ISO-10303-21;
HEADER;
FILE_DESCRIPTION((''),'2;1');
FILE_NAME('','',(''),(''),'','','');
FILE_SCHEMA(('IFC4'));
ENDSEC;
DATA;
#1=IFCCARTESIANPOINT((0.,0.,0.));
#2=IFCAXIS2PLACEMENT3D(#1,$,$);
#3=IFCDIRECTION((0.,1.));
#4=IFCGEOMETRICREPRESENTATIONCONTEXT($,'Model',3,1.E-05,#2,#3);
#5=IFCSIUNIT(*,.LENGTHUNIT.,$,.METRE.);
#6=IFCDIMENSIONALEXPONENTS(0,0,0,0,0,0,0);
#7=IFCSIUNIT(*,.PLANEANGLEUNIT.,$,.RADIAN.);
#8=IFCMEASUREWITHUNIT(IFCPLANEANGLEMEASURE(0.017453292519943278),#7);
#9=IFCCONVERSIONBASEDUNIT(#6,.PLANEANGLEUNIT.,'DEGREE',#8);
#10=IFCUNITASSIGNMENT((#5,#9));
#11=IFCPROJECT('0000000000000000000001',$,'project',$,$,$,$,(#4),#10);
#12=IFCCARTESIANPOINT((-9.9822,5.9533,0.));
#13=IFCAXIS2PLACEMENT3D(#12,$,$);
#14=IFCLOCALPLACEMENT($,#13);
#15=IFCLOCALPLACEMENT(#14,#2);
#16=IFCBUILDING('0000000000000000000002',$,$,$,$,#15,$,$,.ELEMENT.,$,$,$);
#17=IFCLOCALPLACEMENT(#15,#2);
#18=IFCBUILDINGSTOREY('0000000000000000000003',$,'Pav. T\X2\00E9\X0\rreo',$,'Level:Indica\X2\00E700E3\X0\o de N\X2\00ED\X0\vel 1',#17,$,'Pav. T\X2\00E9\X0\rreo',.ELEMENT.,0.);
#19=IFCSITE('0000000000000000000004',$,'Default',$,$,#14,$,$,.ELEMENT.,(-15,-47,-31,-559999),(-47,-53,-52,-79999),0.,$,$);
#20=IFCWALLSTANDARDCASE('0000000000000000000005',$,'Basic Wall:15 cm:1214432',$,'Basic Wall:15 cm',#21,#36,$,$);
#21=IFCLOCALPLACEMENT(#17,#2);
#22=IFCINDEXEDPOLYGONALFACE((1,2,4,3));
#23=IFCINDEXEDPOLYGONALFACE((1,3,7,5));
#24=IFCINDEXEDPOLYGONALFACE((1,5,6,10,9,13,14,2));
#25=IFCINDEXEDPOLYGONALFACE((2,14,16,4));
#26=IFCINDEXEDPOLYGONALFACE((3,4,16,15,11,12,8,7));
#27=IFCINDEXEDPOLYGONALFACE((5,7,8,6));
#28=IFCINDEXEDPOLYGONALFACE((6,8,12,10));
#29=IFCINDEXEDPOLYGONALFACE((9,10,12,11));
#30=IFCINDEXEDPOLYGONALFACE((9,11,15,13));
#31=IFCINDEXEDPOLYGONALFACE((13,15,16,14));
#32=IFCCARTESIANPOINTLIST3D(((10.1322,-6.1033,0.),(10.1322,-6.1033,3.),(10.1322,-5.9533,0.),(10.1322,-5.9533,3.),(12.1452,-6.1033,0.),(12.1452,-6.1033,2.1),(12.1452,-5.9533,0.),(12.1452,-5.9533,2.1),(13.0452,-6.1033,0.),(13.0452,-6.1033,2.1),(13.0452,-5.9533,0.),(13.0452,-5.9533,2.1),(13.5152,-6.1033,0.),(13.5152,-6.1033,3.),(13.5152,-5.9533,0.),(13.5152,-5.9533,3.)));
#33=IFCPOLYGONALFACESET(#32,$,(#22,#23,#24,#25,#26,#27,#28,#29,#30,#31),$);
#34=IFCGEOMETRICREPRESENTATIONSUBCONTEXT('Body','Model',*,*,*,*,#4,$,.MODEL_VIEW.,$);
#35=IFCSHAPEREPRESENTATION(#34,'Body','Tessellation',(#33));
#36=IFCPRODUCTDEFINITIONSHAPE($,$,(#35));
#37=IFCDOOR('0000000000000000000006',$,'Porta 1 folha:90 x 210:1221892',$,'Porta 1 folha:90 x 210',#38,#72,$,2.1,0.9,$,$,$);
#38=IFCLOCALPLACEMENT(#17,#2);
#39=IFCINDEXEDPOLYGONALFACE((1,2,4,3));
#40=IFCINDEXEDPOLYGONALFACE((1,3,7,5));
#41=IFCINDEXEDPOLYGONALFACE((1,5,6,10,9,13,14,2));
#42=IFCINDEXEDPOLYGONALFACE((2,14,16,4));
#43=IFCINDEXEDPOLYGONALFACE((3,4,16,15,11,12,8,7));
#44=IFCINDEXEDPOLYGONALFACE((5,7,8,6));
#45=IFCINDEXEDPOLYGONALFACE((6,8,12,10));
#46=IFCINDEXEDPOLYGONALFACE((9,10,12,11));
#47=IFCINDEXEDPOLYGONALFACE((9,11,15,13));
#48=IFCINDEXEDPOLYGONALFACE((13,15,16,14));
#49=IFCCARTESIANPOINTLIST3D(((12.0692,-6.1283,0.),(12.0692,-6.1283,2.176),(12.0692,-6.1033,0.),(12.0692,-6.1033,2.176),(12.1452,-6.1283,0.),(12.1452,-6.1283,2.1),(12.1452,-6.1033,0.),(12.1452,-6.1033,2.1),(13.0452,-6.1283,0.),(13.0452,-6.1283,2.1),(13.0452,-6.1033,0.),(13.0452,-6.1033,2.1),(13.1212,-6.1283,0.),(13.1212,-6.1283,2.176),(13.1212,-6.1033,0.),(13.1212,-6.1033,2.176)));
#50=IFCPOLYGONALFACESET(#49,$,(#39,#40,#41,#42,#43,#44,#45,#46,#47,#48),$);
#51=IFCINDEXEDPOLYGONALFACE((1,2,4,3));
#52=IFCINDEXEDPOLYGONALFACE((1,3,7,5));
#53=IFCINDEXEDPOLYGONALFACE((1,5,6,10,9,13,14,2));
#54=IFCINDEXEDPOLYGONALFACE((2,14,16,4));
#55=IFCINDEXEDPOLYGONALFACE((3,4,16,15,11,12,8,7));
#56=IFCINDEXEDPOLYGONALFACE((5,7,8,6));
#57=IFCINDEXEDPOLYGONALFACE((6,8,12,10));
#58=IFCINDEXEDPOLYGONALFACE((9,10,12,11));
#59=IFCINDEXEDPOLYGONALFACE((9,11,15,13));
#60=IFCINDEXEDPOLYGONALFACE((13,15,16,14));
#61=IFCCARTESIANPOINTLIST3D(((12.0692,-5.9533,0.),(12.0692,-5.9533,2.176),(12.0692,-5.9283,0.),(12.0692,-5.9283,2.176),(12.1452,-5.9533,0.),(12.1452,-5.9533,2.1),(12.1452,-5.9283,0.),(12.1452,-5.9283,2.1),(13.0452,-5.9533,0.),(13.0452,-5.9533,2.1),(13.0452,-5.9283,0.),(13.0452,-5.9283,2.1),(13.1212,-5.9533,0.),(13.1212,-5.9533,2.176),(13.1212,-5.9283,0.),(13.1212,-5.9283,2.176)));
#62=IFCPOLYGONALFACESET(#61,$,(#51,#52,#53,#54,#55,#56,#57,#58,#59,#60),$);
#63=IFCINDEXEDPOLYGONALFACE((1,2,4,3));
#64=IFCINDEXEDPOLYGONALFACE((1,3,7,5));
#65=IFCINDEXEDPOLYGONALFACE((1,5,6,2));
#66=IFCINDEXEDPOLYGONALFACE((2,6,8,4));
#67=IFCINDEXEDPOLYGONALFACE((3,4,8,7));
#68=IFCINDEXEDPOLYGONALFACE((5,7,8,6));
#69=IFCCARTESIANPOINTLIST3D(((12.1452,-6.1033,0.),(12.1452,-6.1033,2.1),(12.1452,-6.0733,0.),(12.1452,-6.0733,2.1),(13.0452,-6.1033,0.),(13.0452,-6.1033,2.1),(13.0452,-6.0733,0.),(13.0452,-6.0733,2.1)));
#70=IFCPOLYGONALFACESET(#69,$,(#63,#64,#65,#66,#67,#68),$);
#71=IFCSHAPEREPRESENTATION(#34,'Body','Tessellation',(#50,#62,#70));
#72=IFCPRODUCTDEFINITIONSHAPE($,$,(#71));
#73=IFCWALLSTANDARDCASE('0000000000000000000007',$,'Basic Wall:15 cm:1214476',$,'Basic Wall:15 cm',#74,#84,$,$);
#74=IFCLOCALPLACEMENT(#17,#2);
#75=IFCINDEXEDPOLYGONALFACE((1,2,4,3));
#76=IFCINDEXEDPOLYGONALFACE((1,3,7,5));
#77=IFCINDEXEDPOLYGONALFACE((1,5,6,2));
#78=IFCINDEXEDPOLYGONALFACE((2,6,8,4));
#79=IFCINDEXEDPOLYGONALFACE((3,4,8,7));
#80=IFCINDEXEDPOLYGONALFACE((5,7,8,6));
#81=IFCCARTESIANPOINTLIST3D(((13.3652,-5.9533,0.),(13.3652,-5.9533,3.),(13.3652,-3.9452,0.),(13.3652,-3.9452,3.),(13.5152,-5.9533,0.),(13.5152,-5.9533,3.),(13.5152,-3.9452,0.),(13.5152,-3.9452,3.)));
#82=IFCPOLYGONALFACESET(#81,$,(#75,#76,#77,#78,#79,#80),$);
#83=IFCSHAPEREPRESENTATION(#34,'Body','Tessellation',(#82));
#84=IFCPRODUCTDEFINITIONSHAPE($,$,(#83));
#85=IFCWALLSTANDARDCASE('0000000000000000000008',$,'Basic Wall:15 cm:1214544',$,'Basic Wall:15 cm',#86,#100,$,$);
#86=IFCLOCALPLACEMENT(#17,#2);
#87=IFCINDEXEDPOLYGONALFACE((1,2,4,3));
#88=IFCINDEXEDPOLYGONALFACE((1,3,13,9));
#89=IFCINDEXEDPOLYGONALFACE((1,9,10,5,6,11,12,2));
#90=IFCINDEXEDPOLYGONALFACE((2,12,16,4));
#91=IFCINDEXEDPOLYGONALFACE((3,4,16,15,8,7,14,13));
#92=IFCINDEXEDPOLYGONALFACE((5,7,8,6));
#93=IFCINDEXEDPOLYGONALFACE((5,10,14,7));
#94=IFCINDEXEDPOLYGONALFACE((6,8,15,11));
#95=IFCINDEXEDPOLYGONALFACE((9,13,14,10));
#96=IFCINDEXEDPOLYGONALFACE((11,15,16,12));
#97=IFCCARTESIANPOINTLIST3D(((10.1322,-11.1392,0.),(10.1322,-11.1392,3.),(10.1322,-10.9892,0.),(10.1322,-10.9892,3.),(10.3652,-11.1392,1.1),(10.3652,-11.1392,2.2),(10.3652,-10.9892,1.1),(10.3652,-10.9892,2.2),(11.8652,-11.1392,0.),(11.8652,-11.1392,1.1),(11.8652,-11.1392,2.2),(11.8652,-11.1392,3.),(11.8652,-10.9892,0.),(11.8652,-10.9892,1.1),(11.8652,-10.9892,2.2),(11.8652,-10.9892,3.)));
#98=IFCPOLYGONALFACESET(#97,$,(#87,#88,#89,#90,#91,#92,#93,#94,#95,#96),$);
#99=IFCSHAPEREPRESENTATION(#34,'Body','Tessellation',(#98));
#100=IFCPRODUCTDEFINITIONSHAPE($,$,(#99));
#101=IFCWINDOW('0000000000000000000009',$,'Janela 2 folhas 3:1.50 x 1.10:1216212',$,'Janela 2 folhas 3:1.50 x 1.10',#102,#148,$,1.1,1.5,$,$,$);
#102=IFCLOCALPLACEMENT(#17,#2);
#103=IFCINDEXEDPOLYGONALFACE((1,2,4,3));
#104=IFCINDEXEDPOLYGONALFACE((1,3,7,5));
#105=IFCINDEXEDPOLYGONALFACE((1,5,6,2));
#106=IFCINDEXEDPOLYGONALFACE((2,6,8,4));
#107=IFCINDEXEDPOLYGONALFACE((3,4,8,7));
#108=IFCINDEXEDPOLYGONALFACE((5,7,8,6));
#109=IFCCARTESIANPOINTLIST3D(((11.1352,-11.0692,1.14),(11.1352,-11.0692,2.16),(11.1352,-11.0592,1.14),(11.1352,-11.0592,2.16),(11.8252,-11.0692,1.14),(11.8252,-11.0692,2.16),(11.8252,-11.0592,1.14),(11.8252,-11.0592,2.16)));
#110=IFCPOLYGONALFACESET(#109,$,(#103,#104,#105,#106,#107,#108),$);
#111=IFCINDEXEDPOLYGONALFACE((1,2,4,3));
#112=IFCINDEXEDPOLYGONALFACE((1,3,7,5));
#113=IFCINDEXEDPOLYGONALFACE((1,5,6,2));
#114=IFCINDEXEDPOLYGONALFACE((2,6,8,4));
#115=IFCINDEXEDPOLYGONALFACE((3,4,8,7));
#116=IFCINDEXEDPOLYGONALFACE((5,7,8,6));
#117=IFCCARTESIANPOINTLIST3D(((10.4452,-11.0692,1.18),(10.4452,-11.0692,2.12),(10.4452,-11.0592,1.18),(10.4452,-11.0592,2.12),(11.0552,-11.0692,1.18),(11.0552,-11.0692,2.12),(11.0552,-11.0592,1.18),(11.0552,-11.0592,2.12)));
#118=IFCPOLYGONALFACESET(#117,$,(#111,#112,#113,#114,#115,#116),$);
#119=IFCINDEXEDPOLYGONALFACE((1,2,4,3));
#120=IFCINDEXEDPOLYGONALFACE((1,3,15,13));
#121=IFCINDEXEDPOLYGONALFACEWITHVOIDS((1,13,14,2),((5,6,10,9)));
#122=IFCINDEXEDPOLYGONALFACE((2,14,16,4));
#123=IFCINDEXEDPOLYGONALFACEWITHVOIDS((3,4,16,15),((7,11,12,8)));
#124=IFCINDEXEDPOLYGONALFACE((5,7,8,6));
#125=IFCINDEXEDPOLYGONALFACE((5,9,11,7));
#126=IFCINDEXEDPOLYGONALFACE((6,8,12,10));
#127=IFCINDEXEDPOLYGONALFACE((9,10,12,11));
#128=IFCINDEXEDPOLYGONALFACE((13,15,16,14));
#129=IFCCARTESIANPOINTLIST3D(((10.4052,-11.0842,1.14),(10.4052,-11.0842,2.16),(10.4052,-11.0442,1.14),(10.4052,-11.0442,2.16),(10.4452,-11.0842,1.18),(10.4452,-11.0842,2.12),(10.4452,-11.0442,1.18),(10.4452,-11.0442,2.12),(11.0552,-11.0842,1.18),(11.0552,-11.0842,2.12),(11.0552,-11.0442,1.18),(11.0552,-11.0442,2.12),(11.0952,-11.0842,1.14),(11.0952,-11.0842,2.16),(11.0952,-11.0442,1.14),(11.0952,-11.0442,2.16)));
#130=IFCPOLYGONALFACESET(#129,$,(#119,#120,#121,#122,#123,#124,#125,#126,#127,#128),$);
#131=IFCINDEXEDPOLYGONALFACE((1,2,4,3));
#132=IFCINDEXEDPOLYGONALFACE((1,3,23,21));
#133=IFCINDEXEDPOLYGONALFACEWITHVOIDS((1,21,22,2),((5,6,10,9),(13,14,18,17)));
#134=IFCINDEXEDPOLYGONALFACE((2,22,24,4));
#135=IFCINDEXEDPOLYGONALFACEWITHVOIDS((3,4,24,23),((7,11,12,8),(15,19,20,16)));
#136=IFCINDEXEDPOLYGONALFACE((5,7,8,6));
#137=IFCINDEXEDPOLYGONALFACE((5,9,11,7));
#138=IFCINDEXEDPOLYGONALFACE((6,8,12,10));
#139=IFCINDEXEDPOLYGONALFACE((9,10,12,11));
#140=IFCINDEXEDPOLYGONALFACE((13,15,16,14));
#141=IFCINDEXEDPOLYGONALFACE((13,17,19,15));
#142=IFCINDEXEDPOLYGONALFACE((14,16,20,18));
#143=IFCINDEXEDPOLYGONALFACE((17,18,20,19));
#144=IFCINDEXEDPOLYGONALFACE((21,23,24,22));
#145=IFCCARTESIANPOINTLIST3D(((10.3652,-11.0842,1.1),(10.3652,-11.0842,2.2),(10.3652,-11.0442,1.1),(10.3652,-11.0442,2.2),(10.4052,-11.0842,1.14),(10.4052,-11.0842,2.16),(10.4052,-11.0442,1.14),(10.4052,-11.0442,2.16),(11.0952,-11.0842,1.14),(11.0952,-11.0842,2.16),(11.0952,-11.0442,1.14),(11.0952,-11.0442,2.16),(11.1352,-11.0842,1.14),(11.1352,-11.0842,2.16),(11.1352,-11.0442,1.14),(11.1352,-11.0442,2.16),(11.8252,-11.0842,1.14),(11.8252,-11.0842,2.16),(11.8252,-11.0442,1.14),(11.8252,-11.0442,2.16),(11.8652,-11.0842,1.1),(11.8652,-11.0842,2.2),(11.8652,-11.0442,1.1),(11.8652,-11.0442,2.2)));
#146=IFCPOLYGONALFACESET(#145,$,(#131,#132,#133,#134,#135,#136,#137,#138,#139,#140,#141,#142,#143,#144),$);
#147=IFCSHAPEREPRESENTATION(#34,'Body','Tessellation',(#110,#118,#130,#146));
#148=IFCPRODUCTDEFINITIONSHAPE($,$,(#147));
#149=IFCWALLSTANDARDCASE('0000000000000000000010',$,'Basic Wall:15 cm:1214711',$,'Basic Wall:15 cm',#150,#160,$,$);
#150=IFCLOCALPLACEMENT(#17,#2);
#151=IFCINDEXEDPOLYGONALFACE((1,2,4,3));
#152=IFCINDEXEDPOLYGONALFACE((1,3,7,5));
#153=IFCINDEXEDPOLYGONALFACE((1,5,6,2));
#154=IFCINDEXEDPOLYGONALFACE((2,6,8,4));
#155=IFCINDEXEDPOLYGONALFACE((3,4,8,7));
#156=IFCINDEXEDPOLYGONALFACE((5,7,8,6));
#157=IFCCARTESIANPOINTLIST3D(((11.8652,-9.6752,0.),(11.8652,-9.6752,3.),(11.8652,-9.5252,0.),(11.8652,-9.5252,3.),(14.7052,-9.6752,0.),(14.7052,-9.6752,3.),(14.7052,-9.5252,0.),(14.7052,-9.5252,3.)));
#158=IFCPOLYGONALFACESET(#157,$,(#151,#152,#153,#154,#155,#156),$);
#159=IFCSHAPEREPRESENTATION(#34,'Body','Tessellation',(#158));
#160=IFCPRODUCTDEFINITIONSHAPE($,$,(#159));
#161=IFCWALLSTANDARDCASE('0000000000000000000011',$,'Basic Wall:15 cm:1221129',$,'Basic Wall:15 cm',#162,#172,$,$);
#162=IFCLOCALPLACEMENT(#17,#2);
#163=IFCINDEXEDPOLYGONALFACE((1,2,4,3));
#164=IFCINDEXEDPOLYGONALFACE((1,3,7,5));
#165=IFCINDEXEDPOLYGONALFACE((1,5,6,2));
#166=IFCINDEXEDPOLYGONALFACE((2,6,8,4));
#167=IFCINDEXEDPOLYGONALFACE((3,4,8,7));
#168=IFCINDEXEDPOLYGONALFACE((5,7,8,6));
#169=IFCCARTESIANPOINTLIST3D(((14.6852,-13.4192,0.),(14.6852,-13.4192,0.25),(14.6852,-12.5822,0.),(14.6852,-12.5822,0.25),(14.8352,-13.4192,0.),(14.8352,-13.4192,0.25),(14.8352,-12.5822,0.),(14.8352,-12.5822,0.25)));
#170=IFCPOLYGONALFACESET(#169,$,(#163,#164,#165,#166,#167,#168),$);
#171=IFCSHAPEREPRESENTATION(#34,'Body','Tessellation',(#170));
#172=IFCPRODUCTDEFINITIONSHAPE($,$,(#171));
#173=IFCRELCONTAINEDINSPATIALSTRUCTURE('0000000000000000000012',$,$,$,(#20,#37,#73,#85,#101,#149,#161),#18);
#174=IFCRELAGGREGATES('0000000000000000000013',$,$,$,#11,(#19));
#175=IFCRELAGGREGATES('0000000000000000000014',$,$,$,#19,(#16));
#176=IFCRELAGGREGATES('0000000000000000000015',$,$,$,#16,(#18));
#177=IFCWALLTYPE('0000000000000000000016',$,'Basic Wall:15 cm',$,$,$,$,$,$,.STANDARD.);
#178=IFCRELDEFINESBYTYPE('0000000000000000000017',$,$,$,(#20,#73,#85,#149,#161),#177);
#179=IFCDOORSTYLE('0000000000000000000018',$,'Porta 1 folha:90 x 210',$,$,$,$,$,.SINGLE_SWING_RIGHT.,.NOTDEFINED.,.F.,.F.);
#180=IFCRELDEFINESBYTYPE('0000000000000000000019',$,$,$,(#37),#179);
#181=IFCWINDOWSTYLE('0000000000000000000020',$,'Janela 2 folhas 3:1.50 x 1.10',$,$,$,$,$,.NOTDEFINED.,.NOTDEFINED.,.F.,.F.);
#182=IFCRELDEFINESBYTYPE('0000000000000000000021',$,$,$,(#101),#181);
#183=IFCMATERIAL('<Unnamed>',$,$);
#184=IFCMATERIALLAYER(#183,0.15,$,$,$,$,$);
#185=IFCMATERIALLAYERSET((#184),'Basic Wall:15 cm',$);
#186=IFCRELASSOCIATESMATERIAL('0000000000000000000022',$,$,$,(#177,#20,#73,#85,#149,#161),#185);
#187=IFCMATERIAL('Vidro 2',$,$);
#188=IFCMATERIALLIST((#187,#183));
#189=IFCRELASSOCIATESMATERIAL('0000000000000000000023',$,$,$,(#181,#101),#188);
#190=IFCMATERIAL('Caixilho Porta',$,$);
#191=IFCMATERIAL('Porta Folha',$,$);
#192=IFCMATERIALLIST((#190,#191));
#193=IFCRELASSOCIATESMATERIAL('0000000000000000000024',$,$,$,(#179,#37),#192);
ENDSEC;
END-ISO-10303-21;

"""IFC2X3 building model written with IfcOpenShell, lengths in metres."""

from ifc_helpers import new_model, entity, si_unit, converted_unit, direction, frame, frame_2d, origin, origin_2d_with_axis, place, context, subcontext, project, spatial, polyline, rectangle, outline, extrude, source, transform, mapped, material, material_list, layer, layer_set, layer_usage, type_object, type_shapes, element, fill, save


model = new_model("IFC2X3")

# Units and contexts
model_context = context("Model", 3, precision=1e-05, world=origin(), true_north=direction((0.0, 1.0)))
body_context = subcontext(model_context, "Body", "Model", "MODEL_VIEW")
ifc_project = project(units=[si_unit("LENGTHUNIT", "METRE"), converted_unit("PLANEANGLEUNIT", "DEGREE", entity("IfcPlaneAngleMeasure", 0.017453292519943278), si_unit("PLANEANGLEUNIT", "RADIAN"), dimensions=[0, 0, 0, 0, 0, 0, 0])], contexts=[model_context])

# Site, building, storey
site_placement = place(None, frame((-9.9822, 5.9533, 0.0)))
site = spatial("IfcSite", under=ifc_project, at=site_placement, Name="Default", CompositionType="ELEMENT", RefLatitude=(-15, -47, -31, -559999), RefLongitude=(-47, -53, -52, -79999), RefElevation=0.0)
building_placement = place(site_placement, origin())
building = spatial("IfcBuilding", under=site, at=building_placement, CompositionType="ELEMENT")
storey_placement = place(building_placement, origin())
storey = spatial("IfcBuildingStorey", under=building, at=storey_placement, Name="Pav. Térreo", ObjectType="Level:Indicação de Nível 1", LongName="Pav. Térreo", CompositionType="ELEMENT", Elevation=0.0)

# Shared definitions
ifc_material_1 = material(Name="<Unnamed>")
ifc_layer_1 = layer(ifc_material_1, 0.15)
ifc_layer_set_1 = layer_set([ifc_layer_1], Name="Basic Wall:15 cm")
wall_type = type_object("IfcWallType", Name="Basic Wall:15 cm", PredefinedType="STANDARD", material=ifc_layer_set_1)

# Shared definitions
ifc_material_2 = material(Name="Vidro 2")
ifc_material_list_1 = material_list([ifc_material_2, ifc_material_1])
window_style_1 = type_object("IfcWindowStyle", Name="Janela 2 folhas 3:1.50 x 1.10", ConstructionType="NOTDEFINED", OperationType="NOTDEFINED", ParameterTakesPrecedence=False, Sizeable=False, material=ifc_material_list_1)
shared_shape_1 = source(origin(), body_context, "Body", "SweptSolid", [
    extrude(rectangle(XDim=0.01, YDim=0.69, at=origin_2d_with_axis()), frame((0.385, 0.075, 0.04), z_axis=(0.0, 0.0, 1.0), x_axis=(0.0, 1.0, 0.0)), (0.0, 0.0, 1.0), 1.02),
    extrude(rectangle(XDim=0.01, YDim=0.61, at=origin_2d_with_axis()), frame((1.115, 0.075, 0.08), z_axis=(0.0, 0.0, 1.0), x_axis=(0.0, 1.0, 0.0)), (0.0, 0.0, 1.0), 0.94),
    extrude(outline(polyline([(-0.345, -0.51), (0.345, -0.51), (0.345, 0.51), (-0.345, 0.51), (-0.345, -0.51)]), holes=[polyline([(-0.305, -0.47), (-0.305, 0.47), (0.305, 0.47), (0.305, -0.47), (-0.305, -0.47)])]), frame((1.115, 0.055, 0.55), z_axis=(0.0, 1.0, 0.0), x_axis=(1.0, 0.0, 0.0)), (0.0, 0.0, 1.0), 0.04),
    extrude(outline(polyline([(-0.55, -0.75), (0.55, -0.75), (0.55, 0.75), (-0.55, 0.75), (-0.55, -0.75)]), holes=[polyline([(0.51, -0.02), (0.51, -0.71), (-0.51, -0.71), (-0.51, -0.02), (0.51, -0.02)]), polyline([(-0.51, 0.02), (-0.51, 0.71), (0.51, 0.71), (0.51, 0.02), (-0.51, 0.02)])]), frame((0.75, 0.055, 0.55), z_axis=(0.0, 1.0, 0.0), x_axis=(0.0, 0.0, -1.0)), (0.0, 0.0, 1.0), 0.04),
])
type_shapes(window_style_1, [shared_shape_1])

# Shared definitions
ifc_material_3 = material(Name="Caixilho Porta")
ifc_material_4 = material(Name="Porta Folha")
ifc_material_list_2 = material_list([ifc_material_3, ifc_material_4])

# Wall, opening, door
ifc_layer_usage_1 = layer_usage(ifc_layer_set_1, "AXIS2", "NEGATIVE", 0.075)
wall_1_placement = place(storey_placement, frame((10.1322, -6.0283, 0.0)))
wall_1 = element("IfcWallStandardCase", 1, at=wall_1_placement, inside=storey, type_object=wall_type, material=ifc_layer_usage_1, Name="Basic Wall:15 cm:1214432", ObjectType="Basic Wall:15 cm", context=body_context, shape_type="SweptSolid", body=[
    extrude(rectangle(XDim=3.383, YDim=0.15, at=frame_2d((1.6915, 0.0), x_axis=(-1.0, 0.0))), origin(), (0.0, 0.0, 1.0), 3.0),
])
opening_1_placement = place(wall_1_placement, frame((2.913, 0.075, 0.0)))
opening_1 = element("IfcOpeningElement", 2, at=opening_1_placement, cuts=wall_1, ObjectType="Opening", context=body_context, shape_type="SweptSolid", body=[
    extrude(rectangle(XDim=0.9, YDim=2.1, at=frame_2d((1.05, 0.45), x_axis=(0.0, 1.0))), frame((0.0, 0.0, 0.0), z_axis=(0.0, -1.0, 0.0), x_axis=(0.0, 0.0, 1.0)), (0.0, 0.0, 1.0), 0.15),
])
door_style_1 = type_object("IfcDoorStyle", Name="Porta 1 folha:90 x 210", ConstructionType="NOTDEFINED", OperationType="SINGLE_SWING_RIGHT", ParameterTakesPrecedence=False, Sizeable=False, material=ifc_material_list_2)
shared_shape_2 = source(origin(), body_context, "Body", "SweptSolid", [
    extrude(outline(polyline([(-0.526, -1.107), (0.526, -1.107), (0.526, 1.069), (0.45, 1.069), (0.45, -1.031), (-0.45, -1.031), (-0.45, 1.069), (-0.526, 1.069), (-0.526, -1.107)])), frame((0.45, 0.15, 1.069), z_axis=(0.0, 1.0, 0.0), x_axis=(1.0, 0.0, 0.0)), (0.0, 0.0, 1.0), 0.025),
    extrude(outline(polyline([(-1.107, -0.526), (1.069, -0.526), (1.069, -0.45), (-1.031, -0.45), (-1.031, 0.45), (1.069, 0.45), (1.069, 0.526), (-1.107, 0.526), (-1.107, -0.526)])), frame((0.45, -0.025, 1.069), z_axis=(0.0, 1.0, 0.0), x_axis=(0.0, 0.0, -1.0)), (0.0, 0.0, 1.0), 0.025),
    extrude(rectangle(XDim=0.03, YDim=0.9, at=origin_2d_with_axis()), frame((0.45, 0.135, 0.0), z_axis=(0.0, 0.0, 1.0), x_axis=(0.0, 1.0, 0.0)), (0.0, 0.0, 1.0), 2.1),
])
type_shapes(door_style_1, [shared_shape_2])
door_1_placement = place(opening_1_placement, frame((0.0, 0.0, 0.0), z_axis=(0.0, 0.0, 1.0), x_axis=(-1.0, 0.0, 0.0)))
door_1 = element("IfcDoor", 3, at=door_1_placement, inside=storey, type_object=door_style_1, material=ifc_material_list_2, Name="Porta 1 folha:90 x 210:1221892", ObjectType="Porta 1 folha:90 x 210", OverallHeight=2.1, OverallWidth=0.9, context=body_context, shape_type="MappedRepresentation", body=[
    mapped(shared_shape_2, transform((0.0, 0.0, 0.0), scale=1.0)),
])
fill(opening_1, door_1)

# Wall
ifc_layer_usage_2 = layer_usage(ifc_layer_set_1, "AXIS2", "NEGATIVE", 0.075)
wall_2_placement = place(storey_placement, frame((13.4402, -5.9533, 0.0), z_axis=(0.0, 0.0, 1.0), x_axis=(0.0, 1.0, 0.0)))
element("IfcWallStandardCase", 4, at=wall_2_placement, inside=storey, type_object=wall_type, material=ifc_layer_usage_2, Name="Basic Wall:15 cm:1214476", ObjectType="Basic Wall:15 cm", context=body_context, shape_type="SweptSolid", body=[
    extrude(rectangle(XDim=2.0081, YDim=0.15, at=frame_2d((1.004, 0.0), x_axis=(-1.0, 0.0))), origin(), (0.0, 0.0, 1.0), 3.0),
])

# Wall, opening, window
ifc_layer_usage_3 = layer_usage(ifc_layer_set_1, "AXIS2", "NEGATIVE", 0.075)
wall_3_placement = place(storey_placement, frame((10.1322, -11.0642, 0.0)))
wall_3 = element("IfcWallStandardCase", 5, at=wall_3_placement, inside=storey, type_object=wall_type, material=ifc_layer_usage_3, Name="Basic Wall:15 cm:1214544", ObjectType="Basic Wall:15 cm", context=body_context, shape_type="SweptSolid", body=[
    extrude(rectangle(XDim=1.733, YDim=0.15, at=frame_2d((0.8665, 0.0), x_axis=(-1.0, 0.0))), origin(), (0.0, 0.0, 1.0), 3.0),
])
opening_2_placement = place(wall_3_placement, frame((1.733, 0.075, 1.1)))
opening_2 = element("IfcOpeningElement", 6, at=opening_2_placement, cuts=wall_3, ObjectType="Opening", context=body_context, shape_type="SweptSolid", body=[
    extrude(rectangle(XDim=1.1, YDim=1.5, at=frame_2d((0.55, 0.75), x_axis=(1.0, 0.0))), frame((0.0, 0.0, 0.0), z_axis=(0.0, -1.0, 0.0), x_axis=(0.0, 0.0, 1.0)), (0.0, 0.0, 1.0), 0.15),
])
window_1_placement = place(opening_2_placement, frame((0.0, 0.0, 0.0), z_axis=(0.0, 0.0, 1.0), x_axis=(-1.0, 0.0, 0.0)))
window_1 = element("IfcWindow", 7, at=window_1_placement, inside=storey, type_object=window_style_1, material=ifc_material_list_1, Name="Janela 2 folhas 3:1.50 x 1.10:1216212", ObjectType="Janela 2 folhas 3:1.50 x 1.10", OverallHeight=1.1, OverallWidth=1.5, context=body_context, shape_type="MappedRepresentation", body=[
    mapped(shared_shape_1, transform((0.0, 0.0, 0.0), scale=1.0)),
])
fill(opening_2, window_1)

# Walls
ifc_layer_usage_4 = layer_usage(ifc_layer_set_1, "AXIS2", "NEGATIVE", 0.075)
wall_4_placement = place(storey_placement, frame((14.7052, -9.6002, 0.0), z_axis=(0.0, 0.0, 1.0), x_axis=(-1.0, 0.0, 0.0)))
element("IfcWallStandardCase", 8, at=wall_4_placement, inside=storey, type_object=wall_type, material=ifc_layer_usage_4, Name="Basic Wall:15 cm:1214711", ObjectType="Basic Wall:15 cm", context=body_context, shape_type="SweptSolid", body=[
    extrude(rectangle(XDim=2.84, YDim=0.15, at=frame_2d((1.42, 0.0), x_axis=(-1.0, 0.0))), origin(), (0.0, 0.0, 1.0), 3.0),
])
ifc_layer_usage_5 = layer_usage(ifc_layer_set_1, "AXIS2", "POSITIVE", -0.075)
wall_5_placement = place(storey_placement, frame((14.7602, -12.5822, 0.0), z_axis=(0.0, 0.0, 1.0), x_axis=(0.0, -1.0, 0.0)))
element("IfcWallStandardCase", 9, at=wall_5_placement, inside=storey, type_object=wall_type, material=ifc_layer_usage_5, Name="Basic Wall:15 cm:1221129", ObjectType="Basic Wall:15 cm", context=body_context, shape_type="SweptSolid", body=[
    extrude(rectangle(XDim=0.837, YDim=0.15, at=frame_2d((0.4185, 0.0), x_axis=(-1.0, 0.0))), origin(), (0.0, 0.0, 1.0), 0.25),
])

save(model, "model.ifc")
